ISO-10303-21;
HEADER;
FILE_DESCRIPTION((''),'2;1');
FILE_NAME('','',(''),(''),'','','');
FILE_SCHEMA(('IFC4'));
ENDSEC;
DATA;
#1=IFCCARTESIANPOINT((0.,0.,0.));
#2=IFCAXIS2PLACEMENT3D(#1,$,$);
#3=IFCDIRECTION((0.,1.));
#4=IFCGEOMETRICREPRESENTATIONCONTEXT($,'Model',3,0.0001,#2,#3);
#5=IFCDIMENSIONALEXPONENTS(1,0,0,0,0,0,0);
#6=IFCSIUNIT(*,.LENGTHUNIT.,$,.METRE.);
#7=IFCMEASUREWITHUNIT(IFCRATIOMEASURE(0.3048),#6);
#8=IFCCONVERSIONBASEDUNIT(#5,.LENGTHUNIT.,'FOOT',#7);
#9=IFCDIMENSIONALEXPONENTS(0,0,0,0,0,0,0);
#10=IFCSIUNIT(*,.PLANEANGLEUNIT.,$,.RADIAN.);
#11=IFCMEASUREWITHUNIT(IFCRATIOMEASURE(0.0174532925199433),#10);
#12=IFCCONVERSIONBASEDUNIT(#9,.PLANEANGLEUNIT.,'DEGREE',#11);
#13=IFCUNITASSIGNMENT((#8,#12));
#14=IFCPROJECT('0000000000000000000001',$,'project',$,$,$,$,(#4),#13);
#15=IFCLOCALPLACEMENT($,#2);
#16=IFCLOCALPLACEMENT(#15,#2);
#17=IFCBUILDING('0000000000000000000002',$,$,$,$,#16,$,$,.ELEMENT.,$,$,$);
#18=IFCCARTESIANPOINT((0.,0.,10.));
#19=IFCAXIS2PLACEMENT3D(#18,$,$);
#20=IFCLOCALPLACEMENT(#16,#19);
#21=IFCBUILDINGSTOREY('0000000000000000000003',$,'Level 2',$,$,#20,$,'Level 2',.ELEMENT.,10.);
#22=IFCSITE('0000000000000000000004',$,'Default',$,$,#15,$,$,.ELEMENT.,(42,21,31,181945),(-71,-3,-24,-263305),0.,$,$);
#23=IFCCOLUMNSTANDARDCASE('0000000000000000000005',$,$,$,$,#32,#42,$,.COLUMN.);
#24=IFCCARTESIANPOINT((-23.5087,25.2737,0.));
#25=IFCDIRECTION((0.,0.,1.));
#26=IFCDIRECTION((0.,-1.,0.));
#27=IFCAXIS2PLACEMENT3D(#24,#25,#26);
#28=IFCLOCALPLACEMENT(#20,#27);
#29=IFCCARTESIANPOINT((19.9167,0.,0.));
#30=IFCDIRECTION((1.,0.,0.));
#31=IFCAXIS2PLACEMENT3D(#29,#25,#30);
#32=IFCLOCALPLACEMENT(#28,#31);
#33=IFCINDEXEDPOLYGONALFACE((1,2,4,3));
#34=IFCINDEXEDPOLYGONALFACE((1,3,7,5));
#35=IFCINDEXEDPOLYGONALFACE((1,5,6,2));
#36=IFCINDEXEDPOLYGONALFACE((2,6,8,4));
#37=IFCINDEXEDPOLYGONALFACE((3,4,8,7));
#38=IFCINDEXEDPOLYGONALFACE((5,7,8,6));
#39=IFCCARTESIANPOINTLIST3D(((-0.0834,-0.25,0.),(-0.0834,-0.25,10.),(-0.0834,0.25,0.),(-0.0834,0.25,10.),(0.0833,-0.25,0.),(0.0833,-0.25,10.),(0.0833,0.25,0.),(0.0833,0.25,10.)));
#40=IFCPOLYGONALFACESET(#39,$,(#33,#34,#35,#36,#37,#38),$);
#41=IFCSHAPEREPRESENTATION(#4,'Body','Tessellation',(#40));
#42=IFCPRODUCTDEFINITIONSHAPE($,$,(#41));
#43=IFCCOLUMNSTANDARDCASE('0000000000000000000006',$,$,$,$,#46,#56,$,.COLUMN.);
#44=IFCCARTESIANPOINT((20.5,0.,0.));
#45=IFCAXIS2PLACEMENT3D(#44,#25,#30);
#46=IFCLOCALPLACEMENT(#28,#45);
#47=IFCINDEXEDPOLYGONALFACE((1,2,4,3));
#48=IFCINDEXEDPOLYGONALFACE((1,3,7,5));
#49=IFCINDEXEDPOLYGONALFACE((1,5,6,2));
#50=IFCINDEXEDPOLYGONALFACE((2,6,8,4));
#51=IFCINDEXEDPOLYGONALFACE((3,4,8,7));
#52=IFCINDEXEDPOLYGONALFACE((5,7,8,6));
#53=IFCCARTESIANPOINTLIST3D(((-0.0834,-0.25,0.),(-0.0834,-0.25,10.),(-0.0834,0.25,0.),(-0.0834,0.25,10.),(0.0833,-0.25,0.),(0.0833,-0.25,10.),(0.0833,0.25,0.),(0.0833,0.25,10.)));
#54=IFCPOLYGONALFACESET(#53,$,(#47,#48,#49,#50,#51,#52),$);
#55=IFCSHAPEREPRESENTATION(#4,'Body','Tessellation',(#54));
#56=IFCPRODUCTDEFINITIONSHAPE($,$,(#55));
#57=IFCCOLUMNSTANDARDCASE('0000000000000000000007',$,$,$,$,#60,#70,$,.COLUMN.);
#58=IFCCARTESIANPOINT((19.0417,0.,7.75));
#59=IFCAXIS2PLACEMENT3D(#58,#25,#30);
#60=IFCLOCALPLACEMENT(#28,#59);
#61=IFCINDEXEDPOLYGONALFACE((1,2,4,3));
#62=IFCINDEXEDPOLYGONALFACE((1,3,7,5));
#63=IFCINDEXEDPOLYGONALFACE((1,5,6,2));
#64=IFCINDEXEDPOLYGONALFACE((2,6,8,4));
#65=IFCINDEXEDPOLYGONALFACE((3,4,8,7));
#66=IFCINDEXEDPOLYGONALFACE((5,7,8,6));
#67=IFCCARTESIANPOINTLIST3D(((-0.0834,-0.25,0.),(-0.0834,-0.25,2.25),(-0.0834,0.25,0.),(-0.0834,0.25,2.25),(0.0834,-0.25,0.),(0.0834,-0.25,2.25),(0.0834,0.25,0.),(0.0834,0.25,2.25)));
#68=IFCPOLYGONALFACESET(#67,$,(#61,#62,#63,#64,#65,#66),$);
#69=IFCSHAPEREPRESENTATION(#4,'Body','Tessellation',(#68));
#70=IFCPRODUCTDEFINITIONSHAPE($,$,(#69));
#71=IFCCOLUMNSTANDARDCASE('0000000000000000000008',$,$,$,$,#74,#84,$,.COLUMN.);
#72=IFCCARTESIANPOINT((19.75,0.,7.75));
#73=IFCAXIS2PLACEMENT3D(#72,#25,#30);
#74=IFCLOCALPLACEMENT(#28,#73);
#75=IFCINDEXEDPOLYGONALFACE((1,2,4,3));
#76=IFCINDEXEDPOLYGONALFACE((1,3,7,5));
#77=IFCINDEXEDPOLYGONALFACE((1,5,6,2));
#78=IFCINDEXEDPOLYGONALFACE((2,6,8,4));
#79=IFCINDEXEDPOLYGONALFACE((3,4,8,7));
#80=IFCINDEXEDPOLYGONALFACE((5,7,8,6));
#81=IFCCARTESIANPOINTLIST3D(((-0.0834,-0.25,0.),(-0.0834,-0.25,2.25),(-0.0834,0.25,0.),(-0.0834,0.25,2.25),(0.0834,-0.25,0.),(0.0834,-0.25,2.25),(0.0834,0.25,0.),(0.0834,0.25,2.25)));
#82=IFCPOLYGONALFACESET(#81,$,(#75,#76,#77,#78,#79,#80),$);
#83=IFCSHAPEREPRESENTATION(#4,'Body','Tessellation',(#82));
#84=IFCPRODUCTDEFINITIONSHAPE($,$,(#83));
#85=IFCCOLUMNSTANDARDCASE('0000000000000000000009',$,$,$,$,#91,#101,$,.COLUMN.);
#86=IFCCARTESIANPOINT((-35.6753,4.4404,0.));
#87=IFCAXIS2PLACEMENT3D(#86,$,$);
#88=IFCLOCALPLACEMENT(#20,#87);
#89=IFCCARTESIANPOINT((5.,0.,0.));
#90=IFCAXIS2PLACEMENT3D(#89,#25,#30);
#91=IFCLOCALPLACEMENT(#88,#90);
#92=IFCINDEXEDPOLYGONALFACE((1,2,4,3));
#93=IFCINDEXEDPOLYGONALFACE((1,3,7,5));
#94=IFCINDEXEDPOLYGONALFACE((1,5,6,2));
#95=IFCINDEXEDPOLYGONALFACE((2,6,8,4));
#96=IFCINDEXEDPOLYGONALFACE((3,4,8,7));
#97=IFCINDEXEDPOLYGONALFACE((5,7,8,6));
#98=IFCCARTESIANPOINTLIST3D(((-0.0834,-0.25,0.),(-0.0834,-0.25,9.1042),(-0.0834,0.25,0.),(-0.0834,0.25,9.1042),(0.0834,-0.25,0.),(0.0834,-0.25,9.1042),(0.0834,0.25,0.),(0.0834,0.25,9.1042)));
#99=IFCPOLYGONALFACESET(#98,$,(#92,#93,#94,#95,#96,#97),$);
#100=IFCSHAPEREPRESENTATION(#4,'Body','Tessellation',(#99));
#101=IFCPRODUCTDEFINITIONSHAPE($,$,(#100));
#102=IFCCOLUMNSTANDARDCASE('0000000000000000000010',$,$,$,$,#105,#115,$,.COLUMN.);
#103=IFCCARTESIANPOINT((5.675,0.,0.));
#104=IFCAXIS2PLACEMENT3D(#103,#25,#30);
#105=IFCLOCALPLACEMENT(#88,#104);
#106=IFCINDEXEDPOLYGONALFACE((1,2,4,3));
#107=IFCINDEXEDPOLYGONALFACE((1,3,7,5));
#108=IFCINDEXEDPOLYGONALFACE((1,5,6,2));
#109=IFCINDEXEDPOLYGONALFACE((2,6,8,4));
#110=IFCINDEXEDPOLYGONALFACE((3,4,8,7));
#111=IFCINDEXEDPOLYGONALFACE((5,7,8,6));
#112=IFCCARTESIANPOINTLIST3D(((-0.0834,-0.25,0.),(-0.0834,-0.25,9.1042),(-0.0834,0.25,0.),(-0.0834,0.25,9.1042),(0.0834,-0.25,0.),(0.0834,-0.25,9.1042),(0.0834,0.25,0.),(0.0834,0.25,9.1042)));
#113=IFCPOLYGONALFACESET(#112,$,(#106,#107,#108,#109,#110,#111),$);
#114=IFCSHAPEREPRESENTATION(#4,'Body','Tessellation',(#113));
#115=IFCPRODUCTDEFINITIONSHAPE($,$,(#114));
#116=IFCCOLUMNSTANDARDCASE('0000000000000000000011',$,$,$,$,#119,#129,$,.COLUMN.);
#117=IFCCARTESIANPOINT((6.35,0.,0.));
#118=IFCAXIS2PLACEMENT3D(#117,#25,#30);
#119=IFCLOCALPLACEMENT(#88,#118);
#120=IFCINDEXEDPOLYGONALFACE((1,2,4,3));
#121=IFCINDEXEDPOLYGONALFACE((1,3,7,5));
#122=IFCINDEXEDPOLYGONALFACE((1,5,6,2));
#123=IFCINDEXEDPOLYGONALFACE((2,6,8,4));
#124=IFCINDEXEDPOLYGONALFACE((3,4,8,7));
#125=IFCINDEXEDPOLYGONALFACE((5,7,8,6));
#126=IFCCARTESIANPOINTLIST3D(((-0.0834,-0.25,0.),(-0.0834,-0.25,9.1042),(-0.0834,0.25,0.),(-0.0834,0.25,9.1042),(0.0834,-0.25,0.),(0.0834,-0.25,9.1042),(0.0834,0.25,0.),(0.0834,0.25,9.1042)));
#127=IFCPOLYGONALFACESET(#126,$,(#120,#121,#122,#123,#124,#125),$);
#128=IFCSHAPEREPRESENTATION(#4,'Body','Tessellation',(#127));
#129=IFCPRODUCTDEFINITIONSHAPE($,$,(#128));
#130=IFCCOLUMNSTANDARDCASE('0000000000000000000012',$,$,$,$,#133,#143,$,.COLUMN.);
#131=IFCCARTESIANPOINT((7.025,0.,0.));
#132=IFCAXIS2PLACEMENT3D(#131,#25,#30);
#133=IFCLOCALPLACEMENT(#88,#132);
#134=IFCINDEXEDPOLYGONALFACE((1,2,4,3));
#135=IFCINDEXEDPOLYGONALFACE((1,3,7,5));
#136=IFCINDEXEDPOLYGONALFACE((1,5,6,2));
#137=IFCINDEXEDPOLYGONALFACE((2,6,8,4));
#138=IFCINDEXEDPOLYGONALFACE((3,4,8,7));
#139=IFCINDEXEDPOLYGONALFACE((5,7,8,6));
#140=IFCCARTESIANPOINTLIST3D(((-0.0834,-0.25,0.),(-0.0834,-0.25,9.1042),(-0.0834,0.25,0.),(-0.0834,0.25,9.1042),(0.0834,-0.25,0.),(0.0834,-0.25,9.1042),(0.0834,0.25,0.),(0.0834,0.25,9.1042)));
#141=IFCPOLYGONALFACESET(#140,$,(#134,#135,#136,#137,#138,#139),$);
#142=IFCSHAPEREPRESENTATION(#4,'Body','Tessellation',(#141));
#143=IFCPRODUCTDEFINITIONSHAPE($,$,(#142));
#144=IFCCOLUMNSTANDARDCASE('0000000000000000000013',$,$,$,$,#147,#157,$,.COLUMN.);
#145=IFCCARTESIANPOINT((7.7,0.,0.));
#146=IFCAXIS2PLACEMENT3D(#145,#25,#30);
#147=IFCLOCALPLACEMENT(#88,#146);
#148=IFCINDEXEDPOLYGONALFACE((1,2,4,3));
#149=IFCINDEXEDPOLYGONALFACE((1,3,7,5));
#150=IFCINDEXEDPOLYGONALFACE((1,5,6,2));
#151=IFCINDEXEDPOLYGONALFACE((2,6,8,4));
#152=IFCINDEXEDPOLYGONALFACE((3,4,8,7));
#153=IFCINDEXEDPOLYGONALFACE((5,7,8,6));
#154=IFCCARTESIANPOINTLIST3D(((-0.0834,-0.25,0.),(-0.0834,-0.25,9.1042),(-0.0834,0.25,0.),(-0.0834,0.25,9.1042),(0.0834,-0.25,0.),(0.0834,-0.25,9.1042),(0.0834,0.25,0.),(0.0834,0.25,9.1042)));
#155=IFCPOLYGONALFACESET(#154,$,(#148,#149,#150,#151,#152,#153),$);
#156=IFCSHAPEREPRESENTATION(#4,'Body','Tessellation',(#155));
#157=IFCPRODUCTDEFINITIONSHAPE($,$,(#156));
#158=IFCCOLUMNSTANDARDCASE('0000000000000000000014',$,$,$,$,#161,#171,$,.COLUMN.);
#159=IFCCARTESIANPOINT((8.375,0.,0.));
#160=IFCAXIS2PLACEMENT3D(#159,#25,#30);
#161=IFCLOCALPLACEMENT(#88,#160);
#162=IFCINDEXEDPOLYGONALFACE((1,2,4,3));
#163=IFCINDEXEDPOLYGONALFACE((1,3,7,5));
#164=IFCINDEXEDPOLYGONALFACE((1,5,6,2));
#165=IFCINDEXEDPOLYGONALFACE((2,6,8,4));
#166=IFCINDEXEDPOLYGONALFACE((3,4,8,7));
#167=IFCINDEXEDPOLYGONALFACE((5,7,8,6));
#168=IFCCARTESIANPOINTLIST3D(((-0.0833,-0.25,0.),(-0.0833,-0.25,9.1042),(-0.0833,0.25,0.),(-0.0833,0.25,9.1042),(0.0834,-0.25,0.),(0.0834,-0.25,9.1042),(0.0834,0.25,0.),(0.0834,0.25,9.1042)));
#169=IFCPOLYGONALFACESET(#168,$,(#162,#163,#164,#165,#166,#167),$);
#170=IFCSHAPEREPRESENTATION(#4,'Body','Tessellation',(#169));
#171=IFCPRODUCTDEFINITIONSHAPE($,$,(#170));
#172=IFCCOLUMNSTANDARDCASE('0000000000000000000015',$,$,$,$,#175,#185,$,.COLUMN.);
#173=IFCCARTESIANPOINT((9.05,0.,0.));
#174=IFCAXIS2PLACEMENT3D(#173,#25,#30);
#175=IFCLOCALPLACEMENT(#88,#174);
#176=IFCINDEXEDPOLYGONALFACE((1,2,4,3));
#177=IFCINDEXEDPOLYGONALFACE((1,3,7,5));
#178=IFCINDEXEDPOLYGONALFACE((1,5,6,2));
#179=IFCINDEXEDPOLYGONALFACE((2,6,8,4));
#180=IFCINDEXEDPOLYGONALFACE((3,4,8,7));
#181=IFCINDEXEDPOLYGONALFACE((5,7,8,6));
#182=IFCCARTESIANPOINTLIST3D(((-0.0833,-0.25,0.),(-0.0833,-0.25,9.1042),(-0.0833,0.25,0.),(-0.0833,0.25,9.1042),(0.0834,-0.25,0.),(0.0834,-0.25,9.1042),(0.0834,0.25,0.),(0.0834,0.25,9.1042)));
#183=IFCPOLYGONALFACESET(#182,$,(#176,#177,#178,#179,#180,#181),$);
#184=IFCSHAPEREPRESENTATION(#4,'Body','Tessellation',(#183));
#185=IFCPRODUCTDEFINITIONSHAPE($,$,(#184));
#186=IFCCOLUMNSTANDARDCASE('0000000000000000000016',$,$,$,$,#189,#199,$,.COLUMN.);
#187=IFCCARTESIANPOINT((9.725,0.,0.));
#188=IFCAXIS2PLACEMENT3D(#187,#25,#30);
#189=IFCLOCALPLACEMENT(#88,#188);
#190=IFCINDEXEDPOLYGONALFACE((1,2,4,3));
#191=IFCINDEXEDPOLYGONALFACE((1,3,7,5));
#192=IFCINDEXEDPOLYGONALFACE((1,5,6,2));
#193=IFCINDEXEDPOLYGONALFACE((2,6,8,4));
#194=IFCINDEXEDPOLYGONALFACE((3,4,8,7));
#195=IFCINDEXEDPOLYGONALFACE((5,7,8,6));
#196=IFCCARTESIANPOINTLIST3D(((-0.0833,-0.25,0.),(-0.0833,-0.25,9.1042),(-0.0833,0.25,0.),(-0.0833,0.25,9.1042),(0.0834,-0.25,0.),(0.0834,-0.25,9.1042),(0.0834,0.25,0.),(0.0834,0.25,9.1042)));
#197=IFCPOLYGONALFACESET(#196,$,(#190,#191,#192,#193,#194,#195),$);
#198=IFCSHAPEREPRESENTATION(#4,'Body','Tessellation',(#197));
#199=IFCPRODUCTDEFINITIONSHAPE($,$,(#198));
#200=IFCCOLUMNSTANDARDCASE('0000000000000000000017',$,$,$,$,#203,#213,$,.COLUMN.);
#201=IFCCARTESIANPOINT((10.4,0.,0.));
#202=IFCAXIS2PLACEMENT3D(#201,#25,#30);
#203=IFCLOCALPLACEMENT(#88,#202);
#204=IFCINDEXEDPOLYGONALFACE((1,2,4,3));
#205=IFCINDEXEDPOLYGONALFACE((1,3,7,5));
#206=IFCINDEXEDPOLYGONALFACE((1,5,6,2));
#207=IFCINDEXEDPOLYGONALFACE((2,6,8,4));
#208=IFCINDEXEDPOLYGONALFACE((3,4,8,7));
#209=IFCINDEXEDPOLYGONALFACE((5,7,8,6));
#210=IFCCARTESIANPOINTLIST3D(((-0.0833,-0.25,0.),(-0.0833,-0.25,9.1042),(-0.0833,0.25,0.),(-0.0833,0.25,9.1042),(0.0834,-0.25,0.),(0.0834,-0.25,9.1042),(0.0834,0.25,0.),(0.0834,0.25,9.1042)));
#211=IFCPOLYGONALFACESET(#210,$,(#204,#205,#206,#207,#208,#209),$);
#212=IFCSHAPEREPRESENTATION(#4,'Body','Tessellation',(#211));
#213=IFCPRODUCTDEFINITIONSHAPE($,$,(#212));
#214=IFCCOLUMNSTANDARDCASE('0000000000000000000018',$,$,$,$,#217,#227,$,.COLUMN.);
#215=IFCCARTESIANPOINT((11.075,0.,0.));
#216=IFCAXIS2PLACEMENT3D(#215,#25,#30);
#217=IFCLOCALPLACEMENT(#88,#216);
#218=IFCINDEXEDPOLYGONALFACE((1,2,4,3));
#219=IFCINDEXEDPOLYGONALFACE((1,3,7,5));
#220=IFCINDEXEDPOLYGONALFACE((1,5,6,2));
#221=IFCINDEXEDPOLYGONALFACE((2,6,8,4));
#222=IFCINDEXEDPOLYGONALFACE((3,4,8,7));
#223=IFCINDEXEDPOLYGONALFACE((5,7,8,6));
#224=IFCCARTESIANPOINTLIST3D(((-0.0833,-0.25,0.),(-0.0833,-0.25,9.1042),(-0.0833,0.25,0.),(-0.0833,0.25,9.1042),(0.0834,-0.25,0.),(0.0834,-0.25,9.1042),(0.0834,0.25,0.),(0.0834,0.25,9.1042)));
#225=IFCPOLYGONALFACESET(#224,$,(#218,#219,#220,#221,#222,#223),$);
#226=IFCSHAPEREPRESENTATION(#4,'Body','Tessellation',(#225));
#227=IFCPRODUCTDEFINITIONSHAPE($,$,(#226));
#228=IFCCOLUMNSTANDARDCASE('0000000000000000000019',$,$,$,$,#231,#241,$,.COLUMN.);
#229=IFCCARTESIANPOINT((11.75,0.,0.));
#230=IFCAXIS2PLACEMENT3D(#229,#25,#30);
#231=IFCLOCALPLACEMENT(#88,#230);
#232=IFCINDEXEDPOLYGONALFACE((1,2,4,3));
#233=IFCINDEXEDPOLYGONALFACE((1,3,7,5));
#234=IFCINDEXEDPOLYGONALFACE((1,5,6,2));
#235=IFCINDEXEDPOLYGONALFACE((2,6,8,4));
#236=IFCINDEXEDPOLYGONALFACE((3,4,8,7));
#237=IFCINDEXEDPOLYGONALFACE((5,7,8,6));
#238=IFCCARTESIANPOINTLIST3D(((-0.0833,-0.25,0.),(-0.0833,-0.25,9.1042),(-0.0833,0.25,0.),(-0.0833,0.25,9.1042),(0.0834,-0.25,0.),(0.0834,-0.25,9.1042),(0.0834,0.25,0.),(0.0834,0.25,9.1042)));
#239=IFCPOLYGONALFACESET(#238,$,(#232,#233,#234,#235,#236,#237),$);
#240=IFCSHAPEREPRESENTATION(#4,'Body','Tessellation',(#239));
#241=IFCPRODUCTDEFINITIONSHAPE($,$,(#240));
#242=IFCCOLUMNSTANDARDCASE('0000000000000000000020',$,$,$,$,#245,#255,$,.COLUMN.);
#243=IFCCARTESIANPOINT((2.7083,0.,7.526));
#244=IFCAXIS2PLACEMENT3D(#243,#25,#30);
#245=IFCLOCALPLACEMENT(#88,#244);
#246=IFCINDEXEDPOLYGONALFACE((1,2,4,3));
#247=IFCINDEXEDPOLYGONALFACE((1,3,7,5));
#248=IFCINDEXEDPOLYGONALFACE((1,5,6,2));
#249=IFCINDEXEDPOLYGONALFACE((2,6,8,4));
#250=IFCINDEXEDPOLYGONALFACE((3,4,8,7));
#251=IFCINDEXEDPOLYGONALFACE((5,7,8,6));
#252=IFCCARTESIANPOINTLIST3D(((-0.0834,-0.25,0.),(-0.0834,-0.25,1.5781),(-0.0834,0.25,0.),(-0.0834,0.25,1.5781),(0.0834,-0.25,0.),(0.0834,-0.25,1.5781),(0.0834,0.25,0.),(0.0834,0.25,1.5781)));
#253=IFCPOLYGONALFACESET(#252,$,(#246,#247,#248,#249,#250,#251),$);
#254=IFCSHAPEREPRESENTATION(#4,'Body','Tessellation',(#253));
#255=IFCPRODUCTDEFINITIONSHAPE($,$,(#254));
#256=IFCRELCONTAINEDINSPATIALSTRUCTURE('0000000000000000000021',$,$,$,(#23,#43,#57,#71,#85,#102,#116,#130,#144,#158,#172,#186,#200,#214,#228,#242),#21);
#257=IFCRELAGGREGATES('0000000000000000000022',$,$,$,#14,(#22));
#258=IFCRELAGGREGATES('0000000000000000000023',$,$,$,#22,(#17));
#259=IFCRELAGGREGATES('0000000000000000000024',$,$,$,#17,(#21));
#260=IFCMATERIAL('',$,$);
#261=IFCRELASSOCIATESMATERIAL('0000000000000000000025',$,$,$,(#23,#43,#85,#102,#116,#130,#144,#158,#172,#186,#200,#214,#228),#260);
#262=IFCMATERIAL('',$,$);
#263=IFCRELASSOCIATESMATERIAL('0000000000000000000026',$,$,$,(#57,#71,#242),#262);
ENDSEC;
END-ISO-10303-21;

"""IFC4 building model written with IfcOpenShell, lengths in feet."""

from ifc_helpers import new_model, entity, si_unit, converted_unit, direction, frame, origin, place, context, project, spatial, rectangle, extrude, material, element, save


model = new_model("IFC4")

# Units and contexts
model_context = context("Model", 3, precision=0.0001, world=origin(), true_north=direction((0.0, 1.0)))
ifc_project = project(units=[converted_unit("LENGTHUNIT", "FOOT", entity("IfcRatioMeasure", 0.3048), si_unit("LENGTHUNIT", "METRE"), dimensions=[1, 0, 0, 0, 0, 0, 0]), converted_unit("PLANEANGLEUNIT", "DEGREE", entity("IfcRatioMeasure", 0.0174532925199433), si_unit("PLANEANGLEUNIT", "RADIAN"), dimensions=[0, 0, 0, 0, 0, 0, 0])], contexts=[model_context])

# Site, building, storey
site_placement = place(None, origin())
site = spatial("IfcSite", under=ifc_project, at=site_placement, Name="Default", CompositionType="ELEMENT", RefLatitude=(42, 21, 31, 181945), RefLongitude=(-71, -3, -24, -263305), RefElevation=0.0)
building_placement = place(site_placement, origin())
building = spatial("IfcBuilding", under=site, at=building_placement, CompositionType="ELEMENT")
storey_placement = place(building_placement, frame((0.0, 0.0, 10.0)))
storey = spatial("IfcBuildingStorey", under=building, at=storey_placement, Name="Level 2", LongName="Level 2", CompositionType="ELEMENT", Elevation=10.0)

# Columns
ifc_material_1 = material(Name="")
placement_1 = place(storey_placement, frame((-23.5087, 25.2737, 0.0), z_axis=(0.0, 0.0, 1.0), x_axis=(0.0, -1.0, 0.0)))
for number, where, z_axis, x_axis in (
    (1, (19.9167, 0.0, 0.0), (0.0, 0.0, 1.0), (1.0, 0.0, 0.0)),
    (2, (20.5, 0.0, 0.0), (0.0, 0.0, 1.0), (1.0, 0.0, 0.0)),
):
    element("IfcColumnStandardCase", number, at=place(placement_1, frame(where, z_axis=z_axis, x_axis=x_axis)), inside=storey, material=ifc_material_1, PredefinedType="COLUMN", context=model_context, shape_type="SweptSolid", body=[
        extrude(rectangle(XDim=0.1667, YDim=0.5), origin(), (0.0, 0.0, 1.0), 10.0),
    ])
ifc_material_2 = material(Name="")
for number, where, z_axis, x_axis in (
    (3, (19.0417, 0.0, 7.75), (0.0, 0.0, 1.0), (1.0, 0.0, 0.0)),
    (4, (19.75, 0.0, 7.75), (0.0, 0.0, 1.0), (1.0, 0.0, 0.0)),
):
    element("IfcColumnStandardCase", number, at=place(placement_1, frame(where, z_axis=z_axis, x_axis=x_axis)), inside=storey, material=ifc_material_2, PredefinedType="COLUMN", context=model_context, shape_type="SweptSolid", body=[
        extrude(rectangle(XDim=0.1667, YDim=0.5), origin(), (0.0, 0.0, 1.0), 2.25),
    ])
placement_2 = place(storey_placement, frame((-35.6753, 4.4404, 0.0)))
for number, where, z_axis, x_axis in (
    (5, (5.0, 0.0, 0.0), (0.0, 0.0, 1.0), (1.0, 0.0, 0.0)),
    (6, (5.675, 0.0, 0.0), (0.0, 0.0, 1.0), (1.0, 0.0, 0.0)),
    (7, (6.35, 0.0, 0.0), (0.0, 0.0, 1.0), (1.0, 0.0, 0.0)),
    (8, (7.025, 0.0, 0.0), (0.0, 0.0, 1.0), (1.0, 0.0, 0.0)),
    (9, (7.7, 0.0, 0.0), (0.0, 0.0, 1.0), (1.0, 0.0, 0.0)),
    (10, (8.375, 0.0, 0.0), (0.0, 0.0, 1.0), (1.0, 0.0, 0.0)),
    (11, (9.05, 0.0, 0.0), (0.0, 0.0, 1.0), (1.0, 0.0, 0.0)),
    (12, (9.725, 0.0, 0.0), (0.0, 0.0, 1.0), (1.0, 0.0, 0.0)),
    (13, (10.4, 0.0, 0.0), (0.0, 0.0, 1.0), (1.0, 0.0, 0.0)),
    (14, (11.075, 0.0, 0.0), (0.0, 0.0, 1.0), (1.0, 0.0, 0.0)),
    (15, (11.75, 0.0, 0.0), (0.0, 0.0, 1.0), (1.0, 0.0, 0.0)),
):
    element("IfcColumnStandardCase", number, at=place(placement_2, frame(where, z_axis=z_axis, x_axis=x_axis)), inside=storey, material=ifc_material_1, PredefinedType="COLUMN", context=model_context, shape_type="SweptSolid", body=[
        extrude(rectangle(XDim=0.1667, YDim=0.5), origin(), (0.0, 0.0, 1.0), 9.1042),
    ])
for number, where, z_axis, x_axis in (
    (16, (2.7083, 0.0, 7.526), (0.0, 0.0, 1.0), (1.0, 0.0, 0.0)),
):
    element("IfcColumnStandardCase", number, at=place(placement_2, frame(where, z_axis=z_axis, x_axis=x_axis)), inside=storey, material=ifc_material_2, PredefinedType="COLUMN", context=model_context, shape_type="SweptSolid", body=[
        extrude(rectangle(XDim=0.1667, YDim=0.5), origin(), (0.0, 0.0, 1.0), 1.5781),
    ])

save(model, "model.ifc")
